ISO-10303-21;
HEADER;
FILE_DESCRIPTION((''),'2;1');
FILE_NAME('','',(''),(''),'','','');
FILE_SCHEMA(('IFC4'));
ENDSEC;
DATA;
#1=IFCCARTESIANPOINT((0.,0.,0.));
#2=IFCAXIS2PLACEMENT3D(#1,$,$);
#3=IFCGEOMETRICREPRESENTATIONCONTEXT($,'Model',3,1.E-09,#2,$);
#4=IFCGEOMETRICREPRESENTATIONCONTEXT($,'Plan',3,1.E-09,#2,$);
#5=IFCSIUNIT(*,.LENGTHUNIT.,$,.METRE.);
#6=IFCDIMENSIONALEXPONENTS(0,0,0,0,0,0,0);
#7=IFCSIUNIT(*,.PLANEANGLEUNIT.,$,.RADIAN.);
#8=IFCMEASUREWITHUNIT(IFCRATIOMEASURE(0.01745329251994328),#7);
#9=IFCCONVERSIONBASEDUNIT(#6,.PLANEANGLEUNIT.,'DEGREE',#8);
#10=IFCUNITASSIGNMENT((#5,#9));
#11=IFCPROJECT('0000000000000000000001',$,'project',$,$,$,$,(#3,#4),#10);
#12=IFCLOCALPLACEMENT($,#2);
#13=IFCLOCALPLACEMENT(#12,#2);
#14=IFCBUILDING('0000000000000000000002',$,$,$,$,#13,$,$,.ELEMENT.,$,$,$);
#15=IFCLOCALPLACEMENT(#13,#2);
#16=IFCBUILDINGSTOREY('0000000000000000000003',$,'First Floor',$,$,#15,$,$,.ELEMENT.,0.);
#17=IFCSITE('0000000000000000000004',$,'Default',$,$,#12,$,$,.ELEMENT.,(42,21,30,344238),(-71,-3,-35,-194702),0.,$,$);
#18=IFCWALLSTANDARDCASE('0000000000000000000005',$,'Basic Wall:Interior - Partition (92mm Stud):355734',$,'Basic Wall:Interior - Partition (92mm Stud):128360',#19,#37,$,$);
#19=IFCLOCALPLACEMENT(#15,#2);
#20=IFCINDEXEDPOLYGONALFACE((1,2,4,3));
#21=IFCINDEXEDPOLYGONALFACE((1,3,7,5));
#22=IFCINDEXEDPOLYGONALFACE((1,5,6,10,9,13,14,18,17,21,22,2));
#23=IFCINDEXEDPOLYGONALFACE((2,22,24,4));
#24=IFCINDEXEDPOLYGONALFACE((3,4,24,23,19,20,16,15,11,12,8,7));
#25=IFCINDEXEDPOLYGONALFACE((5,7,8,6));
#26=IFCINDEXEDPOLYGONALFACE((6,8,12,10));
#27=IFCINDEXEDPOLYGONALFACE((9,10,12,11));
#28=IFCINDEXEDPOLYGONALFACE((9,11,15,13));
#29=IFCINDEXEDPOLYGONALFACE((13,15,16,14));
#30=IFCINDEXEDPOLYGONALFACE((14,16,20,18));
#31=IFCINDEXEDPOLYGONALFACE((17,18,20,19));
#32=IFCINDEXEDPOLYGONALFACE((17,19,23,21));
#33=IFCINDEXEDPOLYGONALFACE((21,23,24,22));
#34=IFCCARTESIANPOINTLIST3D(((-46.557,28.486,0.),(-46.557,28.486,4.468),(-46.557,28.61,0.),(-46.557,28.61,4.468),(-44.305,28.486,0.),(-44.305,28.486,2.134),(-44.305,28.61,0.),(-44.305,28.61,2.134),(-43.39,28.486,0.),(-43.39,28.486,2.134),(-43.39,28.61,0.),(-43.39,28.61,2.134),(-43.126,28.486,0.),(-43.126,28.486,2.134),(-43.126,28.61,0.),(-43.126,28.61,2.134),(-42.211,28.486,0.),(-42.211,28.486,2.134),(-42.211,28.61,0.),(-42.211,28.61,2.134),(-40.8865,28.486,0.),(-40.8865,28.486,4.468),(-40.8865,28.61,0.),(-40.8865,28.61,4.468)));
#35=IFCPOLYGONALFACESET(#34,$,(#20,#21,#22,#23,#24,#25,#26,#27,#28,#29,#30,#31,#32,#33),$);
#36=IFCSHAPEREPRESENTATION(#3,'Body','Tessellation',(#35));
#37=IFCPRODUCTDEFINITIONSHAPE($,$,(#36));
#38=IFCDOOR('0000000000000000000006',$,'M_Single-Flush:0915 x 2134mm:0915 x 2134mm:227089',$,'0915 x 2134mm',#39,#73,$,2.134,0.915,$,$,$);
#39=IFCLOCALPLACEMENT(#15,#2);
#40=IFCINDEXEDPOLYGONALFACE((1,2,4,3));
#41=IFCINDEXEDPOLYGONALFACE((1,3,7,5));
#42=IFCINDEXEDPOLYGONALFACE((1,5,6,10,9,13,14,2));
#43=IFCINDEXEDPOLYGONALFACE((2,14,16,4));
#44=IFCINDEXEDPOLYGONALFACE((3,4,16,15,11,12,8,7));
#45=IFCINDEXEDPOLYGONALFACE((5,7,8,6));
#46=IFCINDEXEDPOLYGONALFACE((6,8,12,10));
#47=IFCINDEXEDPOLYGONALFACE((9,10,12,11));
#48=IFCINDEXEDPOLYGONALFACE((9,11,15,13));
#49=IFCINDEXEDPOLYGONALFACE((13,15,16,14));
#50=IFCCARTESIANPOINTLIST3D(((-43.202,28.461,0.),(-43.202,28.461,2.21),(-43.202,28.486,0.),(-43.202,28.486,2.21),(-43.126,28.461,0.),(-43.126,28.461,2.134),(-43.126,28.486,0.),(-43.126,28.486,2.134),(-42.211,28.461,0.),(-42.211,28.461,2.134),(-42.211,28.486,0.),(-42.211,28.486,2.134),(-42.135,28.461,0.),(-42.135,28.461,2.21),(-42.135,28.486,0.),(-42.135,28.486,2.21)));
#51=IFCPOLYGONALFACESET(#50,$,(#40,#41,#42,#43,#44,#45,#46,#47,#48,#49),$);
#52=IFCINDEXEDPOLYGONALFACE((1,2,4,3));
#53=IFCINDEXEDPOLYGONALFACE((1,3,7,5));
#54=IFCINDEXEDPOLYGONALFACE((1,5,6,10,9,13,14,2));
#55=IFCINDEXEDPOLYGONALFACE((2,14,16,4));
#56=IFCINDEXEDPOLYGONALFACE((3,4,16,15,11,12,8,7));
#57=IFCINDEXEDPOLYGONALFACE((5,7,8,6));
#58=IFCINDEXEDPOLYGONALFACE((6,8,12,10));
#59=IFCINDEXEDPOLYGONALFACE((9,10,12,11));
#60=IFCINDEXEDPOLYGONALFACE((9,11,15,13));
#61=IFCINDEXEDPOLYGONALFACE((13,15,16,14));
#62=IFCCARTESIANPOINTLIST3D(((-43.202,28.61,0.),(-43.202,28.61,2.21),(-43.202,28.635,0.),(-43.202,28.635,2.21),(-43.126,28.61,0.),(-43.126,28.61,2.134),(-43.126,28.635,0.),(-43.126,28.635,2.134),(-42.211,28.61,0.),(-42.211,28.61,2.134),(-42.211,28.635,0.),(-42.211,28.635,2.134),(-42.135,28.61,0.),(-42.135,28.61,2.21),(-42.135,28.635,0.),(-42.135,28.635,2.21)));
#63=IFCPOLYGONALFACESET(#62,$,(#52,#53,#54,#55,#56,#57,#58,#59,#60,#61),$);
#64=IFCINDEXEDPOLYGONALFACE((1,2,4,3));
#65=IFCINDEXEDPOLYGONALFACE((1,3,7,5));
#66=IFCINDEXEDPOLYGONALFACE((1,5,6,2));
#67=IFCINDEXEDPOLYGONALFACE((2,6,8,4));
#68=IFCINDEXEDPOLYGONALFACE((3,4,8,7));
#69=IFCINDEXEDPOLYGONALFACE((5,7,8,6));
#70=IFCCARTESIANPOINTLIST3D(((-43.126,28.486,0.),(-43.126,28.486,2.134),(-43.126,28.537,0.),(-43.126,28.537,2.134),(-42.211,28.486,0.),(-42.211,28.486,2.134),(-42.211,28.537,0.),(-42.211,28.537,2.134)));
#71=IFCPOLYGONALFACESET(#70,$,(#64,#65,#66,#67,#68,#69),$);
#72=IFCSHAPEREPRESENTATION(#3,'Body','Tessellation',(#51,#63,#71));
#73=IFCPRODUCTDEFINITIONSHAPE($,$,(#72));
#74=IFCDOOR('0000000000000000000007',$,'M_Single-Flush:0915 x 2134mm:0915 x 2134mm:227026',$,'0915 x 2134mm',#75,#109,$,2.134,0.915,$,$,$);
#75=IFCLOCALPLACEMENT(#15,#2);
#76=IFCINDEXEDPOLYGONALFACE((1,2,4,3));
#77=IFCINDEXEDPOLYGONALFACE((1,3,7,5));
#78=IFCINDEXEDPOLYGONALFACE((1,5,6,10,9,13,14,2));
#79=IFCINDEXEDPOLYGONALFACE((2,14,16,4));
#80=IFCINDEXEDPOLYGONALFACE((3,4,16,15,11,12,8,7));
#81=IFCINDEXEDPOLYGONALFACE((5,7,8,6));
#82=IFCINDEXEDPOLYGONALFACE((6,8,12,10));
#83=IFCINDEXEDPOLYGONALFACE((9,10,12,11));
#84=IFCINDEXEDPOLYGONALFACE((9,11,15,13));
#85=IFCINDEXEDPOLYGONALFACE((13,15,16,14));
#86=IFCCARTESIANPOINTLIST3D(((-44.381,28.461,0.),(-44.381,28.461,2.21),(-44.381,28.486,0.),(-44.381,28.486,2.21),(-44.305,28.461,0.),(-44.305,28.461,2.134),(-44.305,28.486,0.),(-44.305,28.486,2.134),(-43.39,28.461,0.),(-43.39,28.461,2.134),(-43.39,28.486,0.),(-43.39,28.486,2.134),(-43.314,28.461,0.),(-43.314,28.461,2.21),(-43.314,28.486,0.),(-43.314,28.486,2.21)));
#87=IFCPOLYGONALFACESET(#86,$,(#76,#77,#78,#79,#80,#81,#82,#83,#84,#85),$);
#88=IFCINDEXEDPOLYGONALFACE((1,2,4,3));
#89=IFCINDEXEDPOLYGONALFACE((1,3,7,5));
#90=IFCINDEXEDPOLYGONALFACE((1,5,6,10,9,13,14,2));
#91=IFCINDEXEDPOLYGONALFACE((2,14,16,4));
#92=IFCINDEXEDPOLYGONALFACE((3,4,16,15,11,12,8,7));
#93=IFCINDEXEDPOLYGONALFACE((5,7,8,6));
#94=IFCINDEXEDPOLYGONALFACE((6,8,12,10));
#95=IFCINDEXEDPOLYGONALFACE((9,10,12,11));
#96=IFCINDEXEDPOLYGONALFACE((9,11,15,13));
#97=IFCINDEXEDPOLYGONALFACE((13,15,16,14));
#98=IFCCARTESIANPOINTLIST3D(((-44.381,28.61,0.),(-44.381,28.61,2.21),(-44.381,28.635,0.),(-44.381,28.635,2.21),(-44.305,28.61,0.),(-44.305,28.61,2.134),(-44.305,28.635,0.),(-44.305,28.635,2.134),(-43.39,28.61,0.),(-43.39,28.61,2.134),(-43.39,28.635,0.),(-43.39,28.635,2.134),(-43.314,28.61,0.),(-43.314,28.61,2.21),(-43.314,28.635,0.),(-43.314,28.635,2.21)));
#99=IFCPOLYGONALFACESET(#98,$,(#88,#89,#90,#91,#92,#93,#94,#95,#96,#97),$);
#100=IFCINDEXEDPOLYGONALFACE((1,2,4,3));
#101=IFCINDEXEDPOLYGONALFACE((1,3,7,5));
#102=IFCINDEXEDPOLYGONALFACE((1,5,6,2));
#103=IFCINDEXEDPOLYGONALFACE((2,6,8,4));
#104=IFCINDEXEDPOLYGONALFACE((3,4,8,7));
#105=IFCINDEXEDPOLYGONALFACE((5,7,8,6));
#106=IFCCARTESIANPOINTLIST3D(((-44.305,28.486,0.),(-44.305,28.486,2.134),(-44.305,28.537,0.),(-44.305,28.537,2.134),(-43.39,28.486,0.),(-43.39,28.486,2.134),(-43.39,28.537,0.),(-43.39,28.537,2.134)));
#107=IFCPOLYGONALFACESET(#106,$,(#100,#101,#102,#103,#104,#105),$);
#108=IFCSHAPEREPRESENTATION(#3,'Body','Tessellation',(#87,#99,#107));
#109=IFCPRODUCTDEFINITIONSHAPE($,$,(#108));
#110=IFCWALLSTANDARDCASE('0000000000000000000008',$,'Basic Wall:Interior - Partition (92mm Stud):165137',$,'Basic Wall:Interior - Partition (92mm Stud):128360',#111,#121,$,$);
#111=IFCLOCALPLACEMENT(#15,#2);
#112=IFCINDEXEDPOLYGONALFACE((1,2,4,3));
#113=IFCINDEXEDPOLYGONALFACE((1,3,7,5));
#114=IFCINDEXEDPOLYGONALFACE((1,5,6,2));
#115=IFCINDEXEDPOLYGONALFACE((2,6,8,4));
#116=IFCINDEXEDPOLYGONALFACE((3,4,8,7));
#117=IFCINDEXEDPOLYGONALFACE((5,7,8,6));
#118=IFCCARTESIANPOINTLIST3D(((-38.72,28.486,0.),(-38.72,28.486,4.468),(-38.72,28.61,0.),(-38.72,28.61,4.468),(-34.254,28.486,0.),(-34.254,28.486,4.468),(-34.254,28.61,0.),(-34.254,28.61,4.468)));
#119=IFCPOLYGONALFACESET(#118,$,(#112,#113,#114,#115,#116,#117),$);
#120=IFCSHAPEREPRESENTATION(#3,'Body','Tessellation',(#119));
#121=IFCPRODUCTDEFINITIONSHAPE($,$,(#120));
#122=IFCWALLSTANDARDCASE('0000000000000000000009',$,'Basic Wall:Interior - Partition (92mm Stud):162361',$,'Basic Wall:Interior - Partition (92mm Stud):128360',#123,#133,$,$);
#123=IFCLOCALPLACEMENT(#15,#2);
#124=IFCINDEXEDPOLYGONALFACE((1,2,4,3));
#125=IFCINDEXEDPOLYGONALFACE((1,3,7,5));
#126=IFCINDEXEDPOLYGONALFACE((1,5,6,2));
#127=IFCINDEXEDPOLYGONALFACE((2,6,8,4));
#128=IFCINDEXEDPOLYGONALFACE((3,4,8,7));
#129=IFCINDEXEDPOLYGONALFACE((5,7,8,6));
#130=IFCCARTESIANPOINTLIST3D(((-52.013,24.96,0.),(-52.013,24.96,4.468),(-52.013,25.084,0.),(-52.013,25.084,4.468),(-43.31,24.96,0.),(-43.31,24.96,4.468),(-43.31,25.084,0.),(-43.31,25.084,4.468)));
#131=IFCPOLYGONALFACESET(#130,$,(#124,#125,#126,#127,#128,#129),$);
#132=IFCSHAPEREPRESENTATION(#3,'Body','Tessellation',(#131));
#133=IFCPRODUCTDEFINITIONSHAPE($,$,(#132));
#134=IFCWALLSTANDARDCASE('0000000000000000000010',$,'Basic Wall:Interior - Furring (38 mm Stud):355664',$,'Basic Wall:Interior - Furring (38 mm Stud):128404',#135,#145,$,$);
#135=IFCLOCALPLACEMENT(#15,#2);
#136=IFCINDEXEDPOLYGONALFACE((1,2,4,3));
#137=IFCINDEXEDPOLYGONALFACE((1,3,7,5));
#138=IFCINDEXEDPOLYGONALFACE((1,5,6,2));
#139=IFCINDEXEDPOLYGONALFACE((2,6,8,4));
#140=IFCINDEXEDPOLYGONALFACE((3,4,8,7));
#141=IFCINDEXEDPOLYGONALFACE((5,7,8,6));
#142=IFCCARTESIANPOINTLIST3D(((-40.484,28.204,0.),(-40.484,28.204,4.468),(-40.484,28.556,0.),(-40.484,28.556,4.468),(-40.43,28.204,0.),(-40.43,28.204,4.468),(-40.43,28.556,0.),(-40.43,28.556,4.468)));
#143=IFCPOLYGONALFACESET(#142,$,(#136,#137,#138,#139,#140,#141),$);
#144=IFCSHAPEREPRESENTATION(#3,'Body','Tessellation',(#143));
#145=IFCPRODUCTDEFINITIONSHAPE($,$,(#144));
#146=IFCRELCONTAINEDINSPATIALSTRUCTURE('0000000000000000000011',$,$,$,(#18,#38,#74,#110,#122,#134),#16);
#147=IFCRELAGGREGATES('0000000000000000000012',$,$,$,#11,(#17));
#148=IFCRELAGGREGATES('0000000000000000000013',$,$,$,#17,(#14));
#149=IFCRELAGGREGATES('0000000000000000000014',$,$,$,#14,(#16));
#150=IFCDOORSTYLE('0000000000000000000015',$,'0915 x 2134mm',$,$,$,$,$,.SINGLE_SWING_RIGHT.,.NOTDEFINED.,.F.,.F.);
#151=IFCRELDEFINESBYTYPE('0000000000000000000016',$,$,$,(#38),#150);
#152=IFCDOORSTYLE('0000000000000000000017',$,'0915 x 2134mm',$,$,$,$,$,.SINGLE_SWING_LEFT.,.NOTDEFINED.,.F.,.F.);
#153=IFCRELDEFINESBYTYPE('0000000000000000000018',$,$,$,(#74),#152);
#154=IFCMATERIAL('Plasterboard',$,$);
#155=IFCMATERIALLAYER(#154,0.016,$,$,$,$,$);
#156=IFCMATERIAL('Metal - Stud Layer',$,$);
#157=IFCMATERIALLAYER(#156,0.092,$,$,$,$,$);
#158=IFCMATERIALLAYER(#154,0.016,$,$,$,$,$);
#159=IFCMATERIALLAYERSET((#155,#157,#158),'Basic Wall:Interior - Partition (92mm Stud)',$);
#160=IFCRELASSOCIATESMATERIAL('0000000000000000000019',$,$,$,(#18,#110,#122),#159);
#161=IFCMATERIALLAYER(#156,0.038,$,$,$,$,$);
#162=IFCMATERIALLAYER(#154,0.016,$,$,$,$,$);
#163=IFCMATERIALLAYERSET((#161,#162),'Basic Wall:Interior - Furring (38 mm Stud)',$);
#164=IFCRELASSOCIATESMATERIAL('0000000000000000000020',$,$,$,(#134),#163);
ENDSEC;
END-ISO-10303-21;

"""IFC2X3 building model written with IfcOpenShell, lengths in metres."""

from ifc_helpers import new_model, entity, si_unit, converted_unit, frame, frame_2d, origin, origin_2d_with_axis, place, context, project, spatial, polyline, rectangle, outline, extrude, source, transform, mapped, material, layer, layer_set, layer_usage, type_object, type_shapes, element, fill, save


model = new_model("IFC2X3")

# Units and contexts
model_context = context("Model", 3, precision=1e-09, world=origin())
plan_context = context("Plan", 3, precision=1e-09, world=origin())
ifc_project = project(units=[si_unit("LENGTHUNIT", "METRE"), converted_unit("PLANEANGLEUNIT", "DEGREE", entity("IfcRatioMeasure", 0.01745329251994328), si_unit("PLANEANGLEUNIT", "RADIAN"), dimensions=[0, 0, 0, 0, 0, 0, 0])], contexts=[model_context, plan_context])

# Site, building, storey
site_placement = place(None, origin())
site = spatial("IfcSite", under=ifc_project, at=site_placement, Name="Default", CompositionType="ELEMENT", RefLatitude=(42, 21, 30, 344238), RefLongitude=(-71, -3, -35, -194702), RefElevation=0.0)
building_placement = place(site_placement, origin())
building = spatial("IfcBuilding", under=site, at=building_placement, CompositionType="ELEMENT")
storey_placement = place(building_placement, origin())
storey = spatial("IfcBuildingStorey", under=building, at=storey_placement, Name="First Floor", CompositionType="ELEMENT", Elevation=0.0)

# Shared definitions
ifc_material_1 = material(Name="Plasterboard")
ifc_layer_1 = layer(ifc_material_1, 0.016)
ifc_material_2 = material(Name="Metal - Stud Layer")
ifc_layer_2 = layer(ifc_material_2, 0.092)
ifc_layer_3 = layer(ifc_material_1, 0.016)
ifc_layer_set_1 = layer_set([ifc_layer_1, ifc_layer_2, ifc_layer_3], Name="Basic Wall:Interior - Partition (92mm Stud)")
ifc_layer_usage_1 = layer_usage(ifc_layer_set_1, "AXIS2", "NEGATIVE", 0.062)
door_style_1 = type_object("IfcDoorStyle", Name="0915 x 2134mm", ConstructionType="NOTDEFINED", OperationType="SINGLE_SWING_RIGHT", ParameterTakesPrecedence=False, Sizeable=False)
shared_shape_1 = source(origin(), model_context, "Body", "SweptSolid", [
    extrude(outline(polyline([(-0.5335, -1.124), (0.5335, -1.124), (0.5335, 1.086), (0.4575, 1.086), (0.4575, -1.048), (-0.4575, -1.048), (-0.4575, 1.086), (-0.5335, 1.086), (-0.5335, -1.124)])), frame((0.4575, 0.124, 1.086), z_axis=(0.0, 1.0, 0.0), x_axis=(1.0, 0.0, 0.0)), (0.0, 0.0, 1.0), 0.025),
    extrude(outline(polyline([(-1.124, -0.5335), (1.086, -0.5335), (1.086, -0.4575), (-1.048, -0.4575), (-1.048, 0.4575), (1.086, 0.4575), (1.086, 0.5335), (-1.124, 0.5335), (-1.124, -0.5335)])), frame((0.4575, -0.025, 1.086), z_axis=(0.0, 1.0, 0.0), x_axis=(0.0, 0.0, -1.0)), (0.0, 0.0, 1.0), 0.025),
    extrude(rectangle(XDim=0.051, YDim=0.915, at=origin_2d_with_axis()), frame((0.4575, 0.0985, 0.0), z_axis=(0.0, 0.0, 1.0), x_axis=(0.0, 1.0, 0.0)), (0.0, 0.0, 1.0), 2.134),
])
type_shapes(door_style_1, [shared_shape_1])
door_style_2 = type_object("IfcDoorStyle", Name="0915 x 2134mm", ConstructionType="NOTDEFINED", OperationType="SINGLE_SWING_LEFT", ParameterTakesPrecedence=False, Sizeable=False)
shared_shape_2 = source(origin(), model_context, "Body", "SweptSolid", [
    extrude(outline(polyline([(-0.5335, -1.124), (0.5335, -1.124), (0.5335, 1.086), (0.4575, 1.086), (0.4575, -1.048), (-0.4575, -1.048), (-0.4575, 1.086), (-0.5335, 1.086), (-0.5335, -1.124)])), frame((0.4575, 0.149, 1.086), z_axis=(0.0, -1.0, 0.0), x_axis=(-1.0, 0.0, 0.0)), (0.0, 0.0, 1.0), 0.025),
    extrude(outline(polyline([(-1.124, -0.5335), (1.086, -0.5335), (1.086, -0.4575), (-1.048, -0.4575), (-1.048, 0.4575), (1.086, 0.4575), (1.086, 0.5335), (-1.124, 0.5335), (-1.124, -0.5335)])), frame((0.4575, 0.0, 1.086), z_axis=(0.0, -1.0, 0.0), x_axis=(0.0, 0.0, -1.0)), (0.0, 0.0, 1.0), 0.025),
    extrude(rectangle(XDim=0.915, YDim=0.051, at=origin_2d_with_axis()), frame((0.4575, 0.0985, 0.0)), (0.0, 0.0, 1.0), 2.134),
])
type_shapes(door_style_2, [shared_shape_2])

# Wall, openings, doors
wall_1_placement = place(storey_placement, frame((-46.557, 28.548, 0.0)))
wall_1 = element("IfcWallStandardCase", 1, at=wall_1_placement, inside=storey, material=ifc_layer_usage_1, Name="Basic Wall:Interior - Partition (92mm Stud):355734", ObjectType="Basic Wall:Interior - Partition (92mm Stud):128360", context=model_context, shape_type="SweptSolid", body=[
    extrude(rectangle(XDim=5.6705, YDim=0.124, at=frame_2d((2.8352, 0.0), x_axis=(-1.0, 0.0))), origin(), (0.0, 0.0, 1.0), 4.468),
])
opening_1_placement = place(wall_1_placement, frame((4.346, 0.062, 0.0)))
opening_1 = element("IfcOpeningElement", 2, at=opening_1_placement, cuts=wall_1, ObjectType="Opening", context=model_context, shape_type="SweptSolid", body=[
    extrude(rectangle(XDim=0.915, YDim=2.134, at=frame_2d((1.067, 0.4575), x_axis=(0.0, 1.0))), frame((0.0, 0.0, 0.0), z_axis=(0.0, -1.0, 0.0), x_axis=(0.0, 0.0, 1.0)), (0.0, 0.0, 1.0), 0.124),
])
opening_2_placement = place(wall_1_placement, frame((3.167, 0.062, 0.0)))
opening_2 = element("IfcOpeningElement", 3, at=opening_2_placement, cuts=wall_1, ObjectType="Opening", context=model_context, shape_type="SweptSolid", body=[
    extrude(rectangle(XDim=0.915, YDim=2.134, at=frame_2d((1.067, 0.4575), x_axis=(0.0, -1.0))), frame((0.0, 0.0, 0.0), z_axis=(0.0, -1.0, 0.0), x_axis=(0.0, 0.0, 1.0)), (0.0, 0.0, 1.0), 0.124),
])
door_1_placement = place(opening_1_placement, frame((0.0, 0.0, 0.0), z_axis=(0.0, 0.0, 1.0), x_axis=(-1.0, 0.0, 0.0)))
door_1 = element("IfcDoor", 4, at=door_1_placement, inside=storey, type_object=door_style_1, Name="M_Single-Flush:0915 x 2134mm:0915 x 2134mm:227089", ObjectType="0915 x 2134mm", OverallHeight=2.134, OverallWidth=0.915, context=model_context, shape_type="MappedRepresentation", body=[
    mapped(shared_shape_1, transform((0.0, 0.0, 0.0), scale=1.0)),
])
fill(opening_1, door_1)
door_2_placement = place(opening_2_placement, frame((0.0, 0.0, 0.0), z_axis=(0.0, 0.0, 1.0), x_axis=(-1.0, 0.0, 0.0)))
door_2 = element("IfcDoor", 5, at=door_2_placement, inside=storey, type_object=door_style_2, Name="M_Single-Flush:0915 x 2134mm:0915 x 2134mm:227026", ObjectType="0915 x 2134mm", OverallHeight=2.134, OverallWidth=0.915, context=model_context, shape_type="MappedRepresentation", body=[
    mapped(shared_shape_2, transform((0.0, 0.0, 0.0), scale=1.0)),
])
fill(opening_2, door_2)

# Walls
wall_2_placement = place(storey_placement, frame((-38.72, 28.548, 0.0)))
element("IfcWallStandardCase", 6, at=wall_2_placement, inside=storey, material=ifc_layer_usage_1, Name="Basic Wall:Interior - Partition (92mm Stud):165137", ObjectType="Basic Wall:Interior - Partition (92mm Stud):128360", context=model_context, shape_type="SweptSolid", body=[
    extrude(rectangle(XDim=4.466, YDim=0.124, at=frame_2d((2.233, 0.0), x_axis=(-1.0, 0.0))), origin(), (0.0, 0.0, 1.0), 4.468),
])
wall_3_placement = place(storey_placement, frame((-43.31, 25.022, 0.0), z_axis=(0.0, 0.0, 1.0), x_axis=(-1.0, 0.0, 0.0)))
element("IfcWallStandardCase", 7, at=wall_3_placement, inside=storey, material=ifc_layer_usage_1, Name="Basic Wall:Interior - Partition (92mm Stud):162361", ObjectType="Basic Wall:Interior - Partition (92mm Stud):128360", context=model_context, shape_type="SweptSolid", body=[
    extrude(rectangle(XDim=8.703, YDim=0.124, at=frame_2d((4.3515, 0.0), x_axis=(-1.0, 0.0))), origin(), (0.0, 0.0, 1.0), 4.468),
])
ifc_layer_4 = layer(ifc_material_2, 0.038)
ifc_layer_5 = layer(ifc_material_1, 0.016)
ifc_layer_set_2 = layer_set([ifc_layer_4, ifc_layer_5], Name="Basic Wall:Interior - Furring (38 mm Stud)")
ifc_layer_usage_2 = layer_usage(ifc_layer_set_2, "AXIS2", "NEGATIVE", 0.027)
wall_4_placement = place(storey_placement, frame((-40.457, 28.204, 0.0), z_axis=(0.0, 0.0, 1.0), x_axis=(0.0, 1.0, 0.0)))
element("IfcWallStandardCase", 8, at=wall_4_placement, inside=storey, material=ifc_layer_usage_2, Name="Basic Wall:Interior - Furring (38 mm Stud):355664", ObjectType="Basic Wall:Interior - Furring (38 mm Stud):128404", context=model_context, shape_type="SweptSolid", body=[
    extrude(rectangle(XDim=0.352, YDim=0.054, at=frame_2d((0.176, 0.0), x_axis=(-1.0, 0.0))), origin(), (0.0, 0.0, 1.0), 4.468),
])

save(model, "model.ifc")
